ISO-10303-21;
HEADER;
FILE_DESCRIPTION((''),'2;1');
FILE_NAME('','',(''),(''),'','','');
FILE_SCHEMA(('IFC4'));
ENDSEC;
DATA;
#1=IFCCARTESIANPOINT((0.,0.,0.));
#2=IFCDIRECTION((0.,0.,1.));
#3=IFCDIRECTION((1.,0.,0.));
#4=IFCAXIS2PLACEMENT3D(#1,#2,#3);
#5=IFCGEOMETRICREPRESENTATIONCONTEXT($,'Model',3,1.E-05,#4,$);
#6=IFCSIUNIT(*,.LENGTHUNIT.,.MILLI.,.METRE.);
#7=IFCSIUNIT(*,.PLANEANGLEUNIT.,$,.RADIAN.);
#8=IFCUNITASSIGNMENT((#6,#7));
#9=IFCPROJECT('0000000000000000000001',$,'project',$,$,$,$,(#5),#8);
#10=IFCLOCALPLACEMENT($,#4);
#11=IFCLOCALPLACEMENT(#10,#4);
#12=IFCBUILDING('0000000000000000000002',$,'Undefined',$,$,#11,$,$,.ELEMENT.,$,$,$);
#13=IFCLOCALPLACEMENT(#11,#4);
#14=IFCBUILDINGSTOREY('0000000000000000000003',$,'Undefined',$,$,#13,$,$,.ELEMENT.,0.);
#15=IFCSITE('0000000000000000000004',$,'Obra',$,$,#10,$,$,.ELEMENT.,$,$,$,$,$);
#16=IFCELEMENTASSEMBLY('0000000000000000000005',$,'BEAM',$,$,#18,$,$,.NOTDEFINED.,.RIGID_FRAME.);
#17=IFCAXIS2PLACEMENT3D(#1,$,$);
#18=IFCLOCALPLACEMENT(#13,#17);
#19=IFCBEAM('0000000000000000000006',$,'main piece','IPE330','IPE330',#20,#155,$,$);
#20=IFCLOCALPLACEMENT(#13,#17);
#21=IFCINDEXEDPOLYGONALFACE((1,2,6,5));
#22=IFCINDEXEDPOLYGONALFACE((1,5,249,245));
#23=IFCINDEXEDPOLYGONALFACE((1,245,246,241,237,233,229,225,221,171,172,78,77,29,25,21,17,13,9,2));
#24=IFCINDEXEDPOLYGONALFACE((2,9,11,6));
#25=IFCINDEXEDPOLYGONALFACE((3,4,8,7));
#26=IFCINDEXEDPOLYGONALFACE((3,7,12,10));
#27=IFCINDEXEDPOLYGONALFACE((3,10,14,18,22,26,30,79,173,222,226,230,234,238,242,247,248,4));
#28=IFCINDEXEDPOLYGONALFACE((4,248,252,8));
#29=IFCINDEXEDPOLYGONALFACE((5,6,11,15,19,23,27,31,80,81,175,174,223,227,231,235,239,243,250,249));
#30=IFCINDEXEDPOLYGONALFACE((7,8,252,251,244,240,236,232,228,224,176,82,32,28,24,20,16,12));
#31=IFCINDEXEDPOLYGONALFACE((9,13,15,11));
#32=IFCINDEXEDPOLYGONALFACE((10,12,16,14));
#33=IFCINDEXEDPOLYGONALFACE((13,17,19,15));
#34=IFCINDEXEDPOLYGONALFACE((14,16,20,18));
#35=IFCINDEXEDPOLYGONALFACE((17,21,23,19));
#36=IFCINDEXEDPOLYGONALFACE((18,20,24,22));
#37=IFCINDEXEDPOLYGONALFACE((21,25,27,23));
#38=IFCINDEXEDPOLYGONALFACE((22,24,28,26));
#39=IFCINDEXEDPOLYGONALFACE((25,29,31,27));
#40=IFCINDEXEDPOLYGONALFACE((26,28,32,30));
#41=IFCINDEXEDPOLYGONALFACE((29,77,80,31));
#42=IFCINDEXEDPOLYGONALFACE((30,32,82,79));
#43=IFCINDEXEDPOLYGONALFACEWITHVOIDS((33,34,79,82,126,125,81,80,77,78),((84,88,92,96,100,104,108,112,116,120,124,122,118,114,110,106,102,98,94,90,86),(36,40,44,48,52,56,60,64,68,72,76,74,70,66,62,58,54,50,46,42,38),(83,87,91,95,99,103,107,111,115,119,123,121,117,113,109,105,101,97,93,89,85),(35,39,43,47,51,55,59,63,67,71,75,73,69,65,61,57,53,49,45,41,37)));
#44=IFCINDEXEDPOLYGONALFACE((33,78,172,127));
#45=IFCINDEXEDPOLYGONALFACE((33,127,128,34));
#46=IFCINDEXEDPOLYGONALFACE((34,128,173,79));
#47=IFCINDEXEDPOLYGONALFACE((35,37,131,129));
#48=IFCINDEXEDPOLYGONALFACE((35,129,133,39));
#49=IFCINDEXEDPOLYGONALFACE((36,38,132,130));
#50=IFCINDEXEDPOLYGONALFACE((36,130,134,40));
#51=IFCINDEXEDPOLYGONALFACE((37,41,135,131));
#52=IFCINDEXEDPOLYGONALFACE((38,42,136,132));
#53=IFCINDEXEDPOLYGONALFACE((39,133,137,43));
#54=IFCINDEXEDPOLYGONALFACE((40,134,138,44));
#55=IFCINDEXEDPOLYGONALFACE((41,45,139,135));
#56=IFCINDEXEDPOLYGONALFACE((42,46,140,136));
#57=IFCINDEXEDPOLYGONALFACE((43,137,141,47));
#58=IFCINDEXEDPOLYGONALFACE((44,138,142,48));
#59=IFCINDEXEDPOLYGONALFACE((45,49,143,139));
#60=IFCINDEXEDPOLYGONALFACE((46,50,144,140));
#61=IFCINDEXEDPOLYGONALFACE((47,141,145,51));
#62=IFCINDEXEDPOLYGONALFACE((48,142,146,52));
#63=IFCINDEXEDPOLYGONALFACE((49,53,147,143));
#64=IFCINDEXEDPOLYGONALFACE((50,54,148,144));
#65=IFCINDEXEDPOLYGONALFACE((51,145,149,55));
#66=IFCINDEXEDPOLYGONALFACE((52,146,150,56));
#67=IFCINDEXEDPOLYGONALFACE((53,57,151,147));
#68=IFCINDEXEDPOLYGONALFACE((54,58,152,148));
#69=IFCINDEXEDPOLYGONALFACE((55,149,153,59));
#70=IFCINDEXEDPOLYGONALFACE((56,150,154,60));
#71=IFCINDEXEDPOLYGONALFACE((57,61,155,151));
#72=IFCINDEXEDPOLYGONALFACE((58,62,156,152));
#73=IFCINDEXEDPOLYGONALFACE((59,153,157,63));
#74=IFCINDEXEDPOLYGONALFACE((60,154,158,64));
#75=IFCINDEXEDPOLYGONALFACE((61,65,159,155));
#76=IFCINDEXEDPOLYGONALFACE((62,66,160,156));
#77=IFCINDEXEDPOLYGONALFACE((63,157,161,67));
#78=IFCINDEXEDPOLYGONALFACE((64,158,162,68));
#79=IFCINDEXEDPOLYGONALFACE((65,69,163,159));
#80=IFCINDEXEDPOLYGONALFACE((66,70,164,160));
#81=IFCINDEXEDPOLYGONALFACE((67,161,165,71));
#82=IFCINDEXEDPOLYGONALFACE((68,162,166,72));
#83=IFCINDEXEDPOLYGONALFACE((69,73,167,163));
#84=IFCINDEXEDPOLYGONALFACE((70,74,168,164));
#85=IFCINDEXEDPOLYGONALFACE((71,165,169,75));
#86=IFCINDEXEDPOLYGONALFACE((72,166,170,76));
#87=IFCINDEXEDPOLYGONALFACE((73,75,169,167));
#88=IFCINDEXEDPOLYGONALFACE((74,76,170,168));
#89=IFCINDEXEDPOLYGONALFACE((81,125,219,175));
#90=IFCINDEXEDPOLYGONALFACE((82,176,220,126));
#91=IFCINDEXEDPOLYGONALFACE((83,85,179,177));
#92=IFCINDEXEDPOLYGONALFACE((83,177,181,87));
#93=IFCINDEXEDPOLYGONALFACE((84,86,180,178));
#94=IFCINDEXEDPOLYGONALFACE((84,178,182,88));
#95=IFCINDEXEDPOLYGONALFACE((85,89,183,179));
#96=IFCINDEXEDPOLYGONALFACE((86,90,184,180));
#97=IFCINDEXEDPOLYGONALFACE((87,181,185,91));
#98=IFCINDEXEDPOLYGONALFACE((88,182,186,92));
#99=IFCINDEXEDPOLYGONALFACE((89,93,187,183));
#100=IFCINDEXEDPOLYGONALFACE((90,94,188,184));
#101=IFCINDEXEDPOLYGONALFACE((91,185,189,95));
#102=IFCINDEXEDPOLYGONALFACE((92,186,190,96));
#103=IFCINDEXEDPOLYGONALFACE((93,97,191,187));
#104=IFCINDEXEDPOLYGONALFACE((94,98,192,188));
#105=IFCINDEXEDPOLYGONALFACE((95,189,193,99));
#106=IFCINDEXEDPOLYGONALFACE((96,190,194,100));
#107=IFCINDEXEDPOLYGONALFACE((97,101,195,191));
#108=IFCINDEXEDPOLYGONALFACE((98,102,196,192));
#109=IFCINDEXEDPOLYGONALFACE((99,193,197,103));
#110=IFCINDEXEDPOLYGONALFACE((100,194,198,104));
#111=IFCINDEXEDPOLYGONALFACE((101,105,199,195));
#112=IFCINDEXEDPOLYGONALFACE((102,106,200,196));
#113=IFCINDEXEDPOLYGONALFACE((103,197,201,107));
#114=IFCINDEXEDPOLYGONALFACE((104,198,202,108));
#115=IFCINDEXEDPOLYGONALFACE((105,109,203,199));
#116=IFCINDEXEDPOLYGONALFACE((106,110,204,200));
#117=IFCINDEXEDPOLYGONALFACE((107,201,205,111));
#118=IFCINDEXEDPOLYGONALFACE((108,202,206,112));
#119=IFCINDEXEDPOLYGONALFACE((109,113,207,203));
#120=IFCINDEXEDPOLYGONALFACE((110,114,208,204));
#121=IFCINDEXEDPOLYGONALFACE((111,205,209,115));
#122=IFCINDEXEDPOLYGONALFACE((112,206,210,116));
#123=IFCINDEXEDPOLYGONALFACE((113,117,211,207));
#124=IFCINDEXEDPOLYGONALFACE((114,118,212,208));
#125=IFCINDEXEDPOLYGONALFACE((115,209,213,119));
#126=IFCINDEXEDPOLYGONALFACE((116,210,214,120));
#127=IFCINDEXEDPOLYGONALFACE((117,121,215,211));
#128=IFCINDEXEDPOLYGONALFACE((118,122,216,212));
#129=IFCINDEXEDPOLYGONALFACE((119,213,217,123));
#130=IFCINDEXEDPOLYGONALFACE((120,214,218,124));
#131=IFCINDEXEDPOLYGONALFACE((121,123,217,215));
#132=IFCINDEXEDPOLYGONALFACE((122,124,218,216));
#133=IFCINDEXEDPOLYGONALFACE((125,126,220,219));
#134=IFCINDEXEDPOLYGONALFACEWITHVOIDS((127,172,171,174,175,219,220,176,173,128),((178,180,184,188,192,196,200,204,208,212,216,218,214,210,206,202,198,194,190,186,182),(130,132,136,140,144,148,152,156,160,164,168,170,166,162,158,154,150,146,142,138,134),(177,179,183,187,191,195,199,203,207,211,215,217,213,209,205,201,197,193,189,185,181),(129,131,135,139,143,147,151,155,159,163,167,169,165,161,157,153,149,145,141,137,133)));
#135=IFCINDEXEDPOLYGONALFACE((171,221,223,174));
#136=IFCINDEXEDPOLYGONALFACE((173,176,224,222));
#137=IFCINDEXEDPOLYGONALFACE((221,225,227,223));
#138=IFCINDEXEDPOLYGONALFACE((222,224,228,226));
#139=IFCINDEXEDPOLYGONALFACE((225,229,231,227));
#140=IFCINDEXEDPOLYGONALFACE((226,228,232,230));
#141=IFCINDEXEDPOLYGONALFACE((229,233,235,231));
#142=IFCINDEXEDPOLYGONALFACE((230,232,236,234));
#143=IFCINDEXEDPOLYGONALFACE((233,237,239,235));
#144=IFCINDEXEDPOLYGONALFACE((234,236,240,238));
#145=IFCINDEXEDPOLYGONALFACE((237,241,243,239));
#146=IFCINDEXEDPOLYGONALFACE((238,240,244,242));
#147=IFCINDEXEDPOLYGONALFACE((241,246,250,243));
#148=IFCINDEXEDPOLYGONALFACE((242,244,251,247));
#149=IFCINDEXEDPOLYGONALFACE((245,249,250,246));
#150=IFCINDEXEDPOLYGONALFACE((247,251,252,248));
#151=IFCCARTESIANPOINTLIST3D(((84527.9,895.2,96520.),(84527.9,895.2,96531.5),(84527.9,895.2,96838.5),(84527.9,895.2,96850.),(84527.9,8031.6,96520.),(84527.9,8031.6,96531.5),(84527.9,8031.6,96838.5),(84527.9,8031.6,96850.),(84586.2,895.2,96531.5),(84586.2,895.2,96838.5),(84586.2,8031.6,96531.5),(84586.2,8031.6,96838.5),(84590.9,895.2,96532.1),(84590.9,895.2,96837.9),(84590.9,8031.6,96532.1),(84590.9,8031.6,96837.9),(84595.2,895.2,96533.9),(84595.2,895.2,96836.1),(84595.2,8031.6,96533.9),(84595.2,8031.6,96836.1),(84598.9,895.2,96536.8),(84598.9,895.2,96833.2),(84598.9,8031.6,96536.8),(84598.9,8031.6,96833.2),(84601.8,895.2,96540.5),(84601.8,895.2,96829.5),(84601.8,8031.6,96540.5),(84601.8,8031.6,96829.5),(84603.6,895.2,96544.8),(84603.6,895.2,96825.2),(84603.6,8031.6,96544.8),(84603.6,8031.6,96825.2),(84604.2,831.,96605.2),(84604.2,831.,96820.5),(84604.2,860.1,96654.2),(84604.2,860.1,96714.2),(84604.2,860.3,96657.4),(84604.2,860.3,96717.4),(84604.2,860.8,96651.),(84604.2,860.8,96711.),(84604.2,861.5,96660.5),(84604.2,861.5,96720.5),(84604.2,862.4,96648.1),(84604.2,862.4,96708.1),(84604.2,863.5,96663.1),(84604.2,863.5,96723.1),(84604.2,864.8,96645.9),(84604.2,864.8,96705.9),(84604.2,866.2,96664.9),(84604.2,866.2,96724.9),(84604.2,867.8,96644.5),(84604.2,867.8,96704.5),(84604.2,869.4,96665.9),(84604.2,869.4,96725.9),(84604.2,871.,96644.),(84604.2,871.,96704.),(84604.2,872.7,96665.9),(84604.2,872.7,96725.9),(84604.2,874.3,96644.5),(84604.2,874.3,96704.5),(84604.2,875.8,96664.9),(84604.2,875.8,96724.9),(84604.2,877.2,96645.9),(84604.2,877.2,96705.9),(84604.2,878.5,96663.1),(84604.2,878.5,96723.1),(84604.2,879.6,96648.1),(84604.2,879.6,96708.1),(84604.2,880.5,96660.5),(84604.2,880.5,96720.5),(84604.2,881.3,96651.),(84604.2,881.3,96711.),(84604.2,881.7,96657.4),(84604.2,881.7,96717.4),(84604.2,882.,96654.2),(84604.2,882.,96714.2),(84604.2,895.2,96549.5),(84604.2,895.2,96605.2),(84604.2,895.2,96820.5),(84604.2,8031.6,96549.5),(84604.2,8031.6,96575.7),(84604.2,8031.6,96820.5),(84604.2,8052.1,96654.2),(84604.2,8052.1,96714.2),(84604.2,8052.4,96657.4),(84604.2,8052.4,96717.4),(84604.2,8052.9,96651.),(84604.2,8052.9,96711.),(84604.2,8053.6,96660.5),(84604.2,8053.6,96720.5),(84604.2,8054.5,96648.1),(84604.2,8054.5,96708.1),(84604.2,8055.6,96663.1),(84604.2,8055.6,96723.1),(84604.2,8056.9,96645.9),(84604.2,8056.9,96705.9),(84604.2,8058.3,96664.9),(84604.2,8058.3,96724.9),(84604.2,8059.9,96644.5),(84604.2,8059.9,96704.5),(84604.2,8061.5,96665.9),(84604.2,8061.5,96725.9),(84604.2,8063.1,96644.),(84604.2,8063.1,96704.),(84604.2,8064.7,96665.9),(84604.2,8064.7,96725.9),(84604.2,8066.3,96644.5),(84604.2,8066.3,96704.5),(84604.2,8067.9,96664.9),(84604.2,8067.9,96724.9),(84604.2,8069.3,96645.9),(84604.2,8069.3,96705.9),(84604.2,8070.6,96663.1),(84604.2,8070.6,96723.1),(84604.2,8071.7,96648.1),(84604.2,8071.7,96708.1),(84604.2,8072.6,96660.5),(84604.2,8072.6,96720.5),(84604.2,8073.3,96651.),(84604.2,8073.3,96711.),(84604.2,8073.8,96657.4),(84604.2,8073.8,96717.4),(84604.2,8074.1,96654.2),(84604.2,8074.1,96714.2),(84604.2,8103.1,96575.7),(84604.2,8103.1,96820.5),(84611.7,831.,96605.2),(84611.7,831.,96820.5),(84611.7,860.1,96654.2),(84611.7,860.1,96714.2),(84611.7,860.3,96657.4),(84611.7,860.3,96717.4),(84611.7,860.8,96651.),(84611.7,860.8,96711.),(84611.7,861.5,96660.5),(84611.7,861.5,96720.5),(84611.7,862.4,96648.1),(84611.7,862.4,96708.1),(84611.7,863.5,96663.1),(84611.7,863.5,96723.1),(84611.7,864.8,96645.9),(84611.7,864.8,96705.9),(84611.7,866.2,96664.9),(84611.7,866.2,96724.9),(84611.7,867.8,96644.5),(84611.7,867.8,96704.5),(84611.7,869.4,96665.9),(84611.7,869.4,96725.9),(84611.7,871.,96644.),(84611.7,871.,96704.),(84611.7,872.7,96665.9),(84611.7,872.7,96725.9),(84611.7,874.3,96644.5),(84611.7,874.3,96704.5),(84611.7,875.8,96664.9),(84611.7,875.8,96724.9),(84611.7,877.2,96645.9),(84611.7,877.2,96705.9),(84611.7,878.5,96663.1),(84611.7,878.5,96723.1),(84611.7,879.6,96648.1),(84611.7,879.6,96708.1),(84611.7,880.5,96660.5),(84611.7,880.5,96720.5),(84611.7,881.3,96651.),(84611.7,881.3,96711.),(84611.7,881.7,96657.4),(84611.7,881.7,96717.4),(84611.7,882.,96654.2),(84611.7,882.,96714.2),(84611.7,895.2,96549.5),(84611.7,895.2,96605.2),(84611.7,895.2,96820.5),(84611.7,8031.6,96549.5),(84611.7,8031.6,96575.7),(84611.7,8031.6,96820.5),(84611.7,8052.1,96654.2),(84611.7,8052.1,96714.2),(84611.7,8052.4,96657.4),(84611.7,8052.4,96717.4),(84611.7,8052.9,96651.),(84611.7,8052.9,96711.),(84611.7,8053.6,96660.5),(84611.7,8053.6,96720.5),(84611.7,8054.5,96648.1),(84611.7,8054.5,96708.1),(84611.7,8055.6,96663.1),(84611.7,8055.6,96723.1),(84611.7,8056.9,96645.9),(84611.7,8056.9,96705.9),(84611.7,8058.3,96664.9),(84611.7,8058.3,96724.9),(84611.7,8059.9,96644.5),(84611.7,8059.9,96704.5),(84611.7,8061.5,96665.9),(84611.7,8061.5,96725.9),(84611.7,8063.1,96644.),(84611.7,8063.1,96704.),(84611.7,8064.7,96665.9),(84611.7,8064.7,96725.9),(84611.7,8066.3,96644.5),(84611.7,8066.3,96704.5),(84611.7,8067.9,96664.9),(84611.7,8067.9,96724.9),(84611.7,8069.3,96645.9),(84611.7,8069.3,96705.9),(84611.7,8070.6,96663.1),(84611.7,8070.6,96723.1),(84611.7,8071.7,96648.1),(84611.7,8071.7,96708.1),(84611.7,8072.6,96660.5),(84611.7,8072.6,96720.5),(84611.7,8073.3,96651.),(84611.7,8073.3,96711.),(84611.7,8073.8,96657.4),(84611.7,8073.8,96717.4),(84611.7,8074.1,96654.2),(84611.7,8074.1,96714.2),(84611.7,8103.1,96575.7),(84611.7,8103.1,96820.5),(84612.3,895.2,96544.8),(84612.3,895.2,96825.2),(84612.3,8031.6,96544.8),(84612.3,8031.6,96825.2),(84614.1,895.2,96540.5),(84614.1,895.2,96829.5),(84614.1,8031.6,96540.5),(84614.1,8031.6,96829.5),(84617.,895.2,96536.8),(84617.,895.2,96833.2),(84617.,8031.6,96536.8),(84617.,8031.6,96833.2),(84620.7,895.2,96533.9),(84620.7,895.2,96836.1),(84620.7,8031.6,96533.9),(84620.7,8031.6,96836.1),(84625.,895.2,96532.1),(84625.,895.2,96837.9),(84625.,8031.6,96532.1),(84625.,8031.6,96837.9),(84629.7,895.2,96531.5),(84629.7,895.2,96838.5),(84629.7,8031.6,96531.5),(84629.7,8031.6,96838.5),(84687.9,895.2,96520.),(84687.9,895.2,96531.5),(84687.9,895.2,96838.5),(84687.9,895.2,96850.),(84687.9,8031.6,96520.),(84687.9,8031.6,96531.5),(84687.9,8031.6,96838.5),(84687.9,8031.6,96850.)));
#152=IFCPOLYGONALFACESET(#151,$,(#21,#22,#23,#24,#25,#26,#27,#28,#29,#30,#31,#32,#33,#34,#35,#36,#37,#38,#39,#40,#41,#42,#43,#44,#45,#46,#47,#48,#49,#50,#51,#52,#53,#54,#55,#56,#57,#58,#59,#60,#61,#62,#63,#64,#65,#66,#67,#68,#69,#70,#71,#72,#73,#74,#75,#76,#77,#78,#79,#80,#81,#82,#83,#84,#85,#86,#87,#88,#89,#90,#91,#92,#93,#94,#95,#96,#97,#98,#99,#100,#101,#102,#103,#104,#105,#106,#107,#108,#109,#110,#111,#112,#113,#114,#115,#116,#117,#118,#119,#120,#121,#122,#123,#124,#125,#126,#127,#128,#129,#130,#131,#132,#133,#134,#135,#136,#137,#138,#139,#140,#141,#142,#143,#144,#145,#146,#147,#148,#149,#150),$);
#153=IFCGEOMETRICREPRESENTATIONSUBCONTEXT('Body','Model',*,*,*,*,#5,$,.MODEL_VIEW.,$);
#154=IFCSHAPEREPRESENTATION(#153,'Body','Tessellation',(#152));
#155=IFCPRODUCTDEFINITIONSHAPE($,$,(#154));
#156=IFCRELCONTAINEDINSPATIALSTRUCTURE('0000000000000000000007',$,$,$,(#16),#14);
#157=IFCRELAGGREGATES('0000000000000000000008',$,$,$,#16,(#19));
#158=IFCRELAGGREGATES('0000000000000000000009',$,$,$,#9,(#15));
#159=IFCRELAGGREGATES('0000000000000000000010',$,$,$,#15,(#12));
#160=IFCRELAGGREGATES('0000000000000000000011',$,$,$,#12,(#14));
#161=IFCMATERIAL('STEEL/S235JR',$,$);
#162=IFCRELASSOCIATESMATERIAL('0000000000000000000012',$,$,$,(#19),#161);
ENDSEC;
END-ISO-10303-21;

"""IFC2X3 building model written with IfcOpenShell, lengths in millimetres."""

from ifc_helpers import new_model, si_unit, frame, origin_with_axes, origin_2d_with_axis, place, context, subcontext, project, spatial, rectangle, circle, i_section, extrude, clip, halfspace, source, transform, mapped, material, element, aggregate, save


model = new_model("IFC2X3")

# Units and contexts
model_context = context("Model", 3, precision=1e-05, world=origin_with_axes())
body_context = subcontext(model_context, "Body", "Model", "MODEL_VIEW")
ifc_project = project(units=[si_unit("LENGTHUNIT", "METRE", prefix="MILLI"), si_unit("PLANEANGLEUNIT", "RADIAN")], contexts=[model_context])

# Site, building, storey
site_placement = place(None, origin_with_axes())
site = spatial("IfcSite", under=ifc_project, at=site_placement, Name="Obra", CompositionType="ELEMENT")
building_placement = place(site_placement, origin_with_axes())
building = spatial("IfcBuilding", under=site, at=building_placement, Name="Undefined", CompositionType="ELEMENT")
storey_placement = place(building_placement, origin_with_axes())
storey = spatial("IfcBuildingStorey", under=building, at=storey_placement, Name="Undefined", CompositionType="ELEMENT", Elevation=0.0)

# Element assembly, beam, openings
ifc_material = material(Name="STEEL/S235JR")
shared_shape_1 = source(origin_with_axes(), body_context, "Body", "SweptSolid", [
    extrude(circle(Radius=11.0, at=origin_2d_with_axis()), frame((0.0, -3.9, 0.0), z_axis=(0.0, 1.0, 0.0), x_axis=(1.0, 0.0, 0.0)), (0.0, 0.0, 1.0), 7.7),
])
assembly_1_placement = place(storey_placement, origin_with_axes())
assembly_1 = element("IfcElementAssembly", 1, at=assembly_1_placement, inside=storey, Name="BEAM", AssemblyPlace="NOTDEFINED", PredefinedType="RIGID_FRAME")
beam_1_placement = place(assembly_1_placement, frame((84607.9, 898.0, 96685.0), z_axis=(0.0, 0.0, 1.0), x_axis=(0.0, 1.0, 0.0)))
beam_1 = element("IfcBeam", 2, at=beam_1_placement, material=ifc_material, Name="main piece", Description="IPE330", ObjectType="IPE330", context=body_context, shape_type="Clipping", body=[
    clip(clip(extrude(i_section(OverallWidth=160.0, OverallDepth=330.0, WebThickness=7.5, FlangeThickness=11.5, FilletRadius=18.0, at=origin_2d_with_axis()), frame((7205.1, 0.0, 0.0), z_axis=(-1.0, 0.0, 0.0), x_axis=(0.0, -1.0, 0.0)), (0.0, 0.0, 1.0), 7272.1), halfspace(frame((7205.1, 0.0, -265.0), z_axis=(-1.0, 0.0, 0.0), x_axis=(0.0, 1.0, 0.0)), True)), halfspace(frame((-66.9, 0.0, -265.0), z_axis=(1.0, 0.0, 0.0), x_axis=(0.0, -1.0, 0.0)), True)),
])
opening_1_placement = place(assembly_1_placement, frame((84607.9, 898.0, 96685.0), z_axis=(0.0, 0.0, 1.0), x_axis=(0.0, 1.0, 0.0)))
element("IfcOpeningElement", 3, at=opening_1_placement, cuts=beam_1, ObjectType="Recess", context=body_context, shape_type="SweptSolid", body=[
    extrude(rectangle(XDim=56.7, YDim=83.5, at=origin_2d_with_axis()), frame((7175.4, 81.0, -137.7), z_axis=(0.0, -1.0, 0.0), x_axis=(0.0, 0.0, -1.0)), (0.0, 0.0, 1.0), 162.0),
])
opening_2_placement = place(assembly_1_placement, frame((84607.9, 898.0, 96685.0), z_axis=(0.0, 0.0, 1.0), x_axis=(0.0, 1.0, 0.0)))
element("IfcOpeningElement", 4, at=opening_2_placement, cuts=beam_1, ObjectType="Recess", context=body_context, shape_type="SweptSolid", body=[
    extrude(rectangle(XDim=30.5, YDim=83.5, at=origin_2d_with_axis()), frame((7175.4, 81.0, 150.8), z_axis=(0.0, -1.0, 0.0), x_axis=(0.0, 0.0, -1.0)), (0.0, 0.0, 1.0), 162.0),
])
opening_3_placement = place(assembly_1_placement, frame((84607.9, 898.0, 96685.0), z_axis=(0.0, 0.0, 1.0), x_axis=(0.0, 1.0, 0.0)))
element("IfcOpeningElement", 5, at=opening_3_placement, cuts=beam_1, ObjectType="Recess", context=body_context, shape_type="SweptSolid", body=[
    extrude(rectangle(XDim=76.2, YDim=86.2, at=origin_2d_with_axis()), frame((-40.8, -81.0, -122.9), z_axis=(0.0, 1.0, 0.0), x_axis=(-1.0, 0.0, 0.0)), (0.0, 0.0, 1.0), 162.0),
])
opening_4_placement = place(assembly_1_placement, frame((84607.9, 898.0, 96685.0), z_axis=(0.0, 0.0, 1.0), x_axis=(0.0, 1.0, 0.0)))
element("IfcOpeningElement", 6, at=opening_4_placement, cuts=beam_1, ObjectType="Recess", context=body_context, shape_type="SweptSolid", body=[
    extrude(rectangle(XDim=30.5, YDim=76.2, at=origin_2d_with_axis()), frame((-40.8, -81.0, 150.8), z_axis=(0.0, 1.0, 0.0), x_axis=(0.0, 0.0, -1.0)), (0.0, 0.0, 1.0), 162.0),
])
opening_5_placement = place(assembly_1_placement, frame((84607.9, 8103.1, 96850.0), z_axis=(0.0, -1.0, 0.0), x_axis=(0.0, 0.0, -1.0)))
element("IfcOpeningElement", 7, at=opening_5_placement, cuts=beam_1, ObjectType="Opening", context=body_context, shape_type="MappedRepresentation", body=[
    mapped(shared_shape_1, transform((135.0, 0.0, 40.0))),
    mapped(shared_shape_1, transform((195.0, 0.0, 40.0))),
])
opening_6_placement = place(assembly_1_placement, frame((84607.9, 831.0, 96850.0), z_axis=(0.0, 1.0, 0.0), x_axis=(0.0, 0.0, -1.0)))
element("IfcOpeningElement", 8, at=opening_6_placement, cuts=beam_1, ObjectType="Opening", context=body_context, shape_type="MappedRepresentation", body=[
    mapped(shared_shape_1, transform((135.0, 0.0, 40.0))),
    mapped(shared_shape_1, transform((195.0, 0.0, 40.0))),
])
aggregate(assembly_1, [beam_1])

save(model, "model.ifc")
